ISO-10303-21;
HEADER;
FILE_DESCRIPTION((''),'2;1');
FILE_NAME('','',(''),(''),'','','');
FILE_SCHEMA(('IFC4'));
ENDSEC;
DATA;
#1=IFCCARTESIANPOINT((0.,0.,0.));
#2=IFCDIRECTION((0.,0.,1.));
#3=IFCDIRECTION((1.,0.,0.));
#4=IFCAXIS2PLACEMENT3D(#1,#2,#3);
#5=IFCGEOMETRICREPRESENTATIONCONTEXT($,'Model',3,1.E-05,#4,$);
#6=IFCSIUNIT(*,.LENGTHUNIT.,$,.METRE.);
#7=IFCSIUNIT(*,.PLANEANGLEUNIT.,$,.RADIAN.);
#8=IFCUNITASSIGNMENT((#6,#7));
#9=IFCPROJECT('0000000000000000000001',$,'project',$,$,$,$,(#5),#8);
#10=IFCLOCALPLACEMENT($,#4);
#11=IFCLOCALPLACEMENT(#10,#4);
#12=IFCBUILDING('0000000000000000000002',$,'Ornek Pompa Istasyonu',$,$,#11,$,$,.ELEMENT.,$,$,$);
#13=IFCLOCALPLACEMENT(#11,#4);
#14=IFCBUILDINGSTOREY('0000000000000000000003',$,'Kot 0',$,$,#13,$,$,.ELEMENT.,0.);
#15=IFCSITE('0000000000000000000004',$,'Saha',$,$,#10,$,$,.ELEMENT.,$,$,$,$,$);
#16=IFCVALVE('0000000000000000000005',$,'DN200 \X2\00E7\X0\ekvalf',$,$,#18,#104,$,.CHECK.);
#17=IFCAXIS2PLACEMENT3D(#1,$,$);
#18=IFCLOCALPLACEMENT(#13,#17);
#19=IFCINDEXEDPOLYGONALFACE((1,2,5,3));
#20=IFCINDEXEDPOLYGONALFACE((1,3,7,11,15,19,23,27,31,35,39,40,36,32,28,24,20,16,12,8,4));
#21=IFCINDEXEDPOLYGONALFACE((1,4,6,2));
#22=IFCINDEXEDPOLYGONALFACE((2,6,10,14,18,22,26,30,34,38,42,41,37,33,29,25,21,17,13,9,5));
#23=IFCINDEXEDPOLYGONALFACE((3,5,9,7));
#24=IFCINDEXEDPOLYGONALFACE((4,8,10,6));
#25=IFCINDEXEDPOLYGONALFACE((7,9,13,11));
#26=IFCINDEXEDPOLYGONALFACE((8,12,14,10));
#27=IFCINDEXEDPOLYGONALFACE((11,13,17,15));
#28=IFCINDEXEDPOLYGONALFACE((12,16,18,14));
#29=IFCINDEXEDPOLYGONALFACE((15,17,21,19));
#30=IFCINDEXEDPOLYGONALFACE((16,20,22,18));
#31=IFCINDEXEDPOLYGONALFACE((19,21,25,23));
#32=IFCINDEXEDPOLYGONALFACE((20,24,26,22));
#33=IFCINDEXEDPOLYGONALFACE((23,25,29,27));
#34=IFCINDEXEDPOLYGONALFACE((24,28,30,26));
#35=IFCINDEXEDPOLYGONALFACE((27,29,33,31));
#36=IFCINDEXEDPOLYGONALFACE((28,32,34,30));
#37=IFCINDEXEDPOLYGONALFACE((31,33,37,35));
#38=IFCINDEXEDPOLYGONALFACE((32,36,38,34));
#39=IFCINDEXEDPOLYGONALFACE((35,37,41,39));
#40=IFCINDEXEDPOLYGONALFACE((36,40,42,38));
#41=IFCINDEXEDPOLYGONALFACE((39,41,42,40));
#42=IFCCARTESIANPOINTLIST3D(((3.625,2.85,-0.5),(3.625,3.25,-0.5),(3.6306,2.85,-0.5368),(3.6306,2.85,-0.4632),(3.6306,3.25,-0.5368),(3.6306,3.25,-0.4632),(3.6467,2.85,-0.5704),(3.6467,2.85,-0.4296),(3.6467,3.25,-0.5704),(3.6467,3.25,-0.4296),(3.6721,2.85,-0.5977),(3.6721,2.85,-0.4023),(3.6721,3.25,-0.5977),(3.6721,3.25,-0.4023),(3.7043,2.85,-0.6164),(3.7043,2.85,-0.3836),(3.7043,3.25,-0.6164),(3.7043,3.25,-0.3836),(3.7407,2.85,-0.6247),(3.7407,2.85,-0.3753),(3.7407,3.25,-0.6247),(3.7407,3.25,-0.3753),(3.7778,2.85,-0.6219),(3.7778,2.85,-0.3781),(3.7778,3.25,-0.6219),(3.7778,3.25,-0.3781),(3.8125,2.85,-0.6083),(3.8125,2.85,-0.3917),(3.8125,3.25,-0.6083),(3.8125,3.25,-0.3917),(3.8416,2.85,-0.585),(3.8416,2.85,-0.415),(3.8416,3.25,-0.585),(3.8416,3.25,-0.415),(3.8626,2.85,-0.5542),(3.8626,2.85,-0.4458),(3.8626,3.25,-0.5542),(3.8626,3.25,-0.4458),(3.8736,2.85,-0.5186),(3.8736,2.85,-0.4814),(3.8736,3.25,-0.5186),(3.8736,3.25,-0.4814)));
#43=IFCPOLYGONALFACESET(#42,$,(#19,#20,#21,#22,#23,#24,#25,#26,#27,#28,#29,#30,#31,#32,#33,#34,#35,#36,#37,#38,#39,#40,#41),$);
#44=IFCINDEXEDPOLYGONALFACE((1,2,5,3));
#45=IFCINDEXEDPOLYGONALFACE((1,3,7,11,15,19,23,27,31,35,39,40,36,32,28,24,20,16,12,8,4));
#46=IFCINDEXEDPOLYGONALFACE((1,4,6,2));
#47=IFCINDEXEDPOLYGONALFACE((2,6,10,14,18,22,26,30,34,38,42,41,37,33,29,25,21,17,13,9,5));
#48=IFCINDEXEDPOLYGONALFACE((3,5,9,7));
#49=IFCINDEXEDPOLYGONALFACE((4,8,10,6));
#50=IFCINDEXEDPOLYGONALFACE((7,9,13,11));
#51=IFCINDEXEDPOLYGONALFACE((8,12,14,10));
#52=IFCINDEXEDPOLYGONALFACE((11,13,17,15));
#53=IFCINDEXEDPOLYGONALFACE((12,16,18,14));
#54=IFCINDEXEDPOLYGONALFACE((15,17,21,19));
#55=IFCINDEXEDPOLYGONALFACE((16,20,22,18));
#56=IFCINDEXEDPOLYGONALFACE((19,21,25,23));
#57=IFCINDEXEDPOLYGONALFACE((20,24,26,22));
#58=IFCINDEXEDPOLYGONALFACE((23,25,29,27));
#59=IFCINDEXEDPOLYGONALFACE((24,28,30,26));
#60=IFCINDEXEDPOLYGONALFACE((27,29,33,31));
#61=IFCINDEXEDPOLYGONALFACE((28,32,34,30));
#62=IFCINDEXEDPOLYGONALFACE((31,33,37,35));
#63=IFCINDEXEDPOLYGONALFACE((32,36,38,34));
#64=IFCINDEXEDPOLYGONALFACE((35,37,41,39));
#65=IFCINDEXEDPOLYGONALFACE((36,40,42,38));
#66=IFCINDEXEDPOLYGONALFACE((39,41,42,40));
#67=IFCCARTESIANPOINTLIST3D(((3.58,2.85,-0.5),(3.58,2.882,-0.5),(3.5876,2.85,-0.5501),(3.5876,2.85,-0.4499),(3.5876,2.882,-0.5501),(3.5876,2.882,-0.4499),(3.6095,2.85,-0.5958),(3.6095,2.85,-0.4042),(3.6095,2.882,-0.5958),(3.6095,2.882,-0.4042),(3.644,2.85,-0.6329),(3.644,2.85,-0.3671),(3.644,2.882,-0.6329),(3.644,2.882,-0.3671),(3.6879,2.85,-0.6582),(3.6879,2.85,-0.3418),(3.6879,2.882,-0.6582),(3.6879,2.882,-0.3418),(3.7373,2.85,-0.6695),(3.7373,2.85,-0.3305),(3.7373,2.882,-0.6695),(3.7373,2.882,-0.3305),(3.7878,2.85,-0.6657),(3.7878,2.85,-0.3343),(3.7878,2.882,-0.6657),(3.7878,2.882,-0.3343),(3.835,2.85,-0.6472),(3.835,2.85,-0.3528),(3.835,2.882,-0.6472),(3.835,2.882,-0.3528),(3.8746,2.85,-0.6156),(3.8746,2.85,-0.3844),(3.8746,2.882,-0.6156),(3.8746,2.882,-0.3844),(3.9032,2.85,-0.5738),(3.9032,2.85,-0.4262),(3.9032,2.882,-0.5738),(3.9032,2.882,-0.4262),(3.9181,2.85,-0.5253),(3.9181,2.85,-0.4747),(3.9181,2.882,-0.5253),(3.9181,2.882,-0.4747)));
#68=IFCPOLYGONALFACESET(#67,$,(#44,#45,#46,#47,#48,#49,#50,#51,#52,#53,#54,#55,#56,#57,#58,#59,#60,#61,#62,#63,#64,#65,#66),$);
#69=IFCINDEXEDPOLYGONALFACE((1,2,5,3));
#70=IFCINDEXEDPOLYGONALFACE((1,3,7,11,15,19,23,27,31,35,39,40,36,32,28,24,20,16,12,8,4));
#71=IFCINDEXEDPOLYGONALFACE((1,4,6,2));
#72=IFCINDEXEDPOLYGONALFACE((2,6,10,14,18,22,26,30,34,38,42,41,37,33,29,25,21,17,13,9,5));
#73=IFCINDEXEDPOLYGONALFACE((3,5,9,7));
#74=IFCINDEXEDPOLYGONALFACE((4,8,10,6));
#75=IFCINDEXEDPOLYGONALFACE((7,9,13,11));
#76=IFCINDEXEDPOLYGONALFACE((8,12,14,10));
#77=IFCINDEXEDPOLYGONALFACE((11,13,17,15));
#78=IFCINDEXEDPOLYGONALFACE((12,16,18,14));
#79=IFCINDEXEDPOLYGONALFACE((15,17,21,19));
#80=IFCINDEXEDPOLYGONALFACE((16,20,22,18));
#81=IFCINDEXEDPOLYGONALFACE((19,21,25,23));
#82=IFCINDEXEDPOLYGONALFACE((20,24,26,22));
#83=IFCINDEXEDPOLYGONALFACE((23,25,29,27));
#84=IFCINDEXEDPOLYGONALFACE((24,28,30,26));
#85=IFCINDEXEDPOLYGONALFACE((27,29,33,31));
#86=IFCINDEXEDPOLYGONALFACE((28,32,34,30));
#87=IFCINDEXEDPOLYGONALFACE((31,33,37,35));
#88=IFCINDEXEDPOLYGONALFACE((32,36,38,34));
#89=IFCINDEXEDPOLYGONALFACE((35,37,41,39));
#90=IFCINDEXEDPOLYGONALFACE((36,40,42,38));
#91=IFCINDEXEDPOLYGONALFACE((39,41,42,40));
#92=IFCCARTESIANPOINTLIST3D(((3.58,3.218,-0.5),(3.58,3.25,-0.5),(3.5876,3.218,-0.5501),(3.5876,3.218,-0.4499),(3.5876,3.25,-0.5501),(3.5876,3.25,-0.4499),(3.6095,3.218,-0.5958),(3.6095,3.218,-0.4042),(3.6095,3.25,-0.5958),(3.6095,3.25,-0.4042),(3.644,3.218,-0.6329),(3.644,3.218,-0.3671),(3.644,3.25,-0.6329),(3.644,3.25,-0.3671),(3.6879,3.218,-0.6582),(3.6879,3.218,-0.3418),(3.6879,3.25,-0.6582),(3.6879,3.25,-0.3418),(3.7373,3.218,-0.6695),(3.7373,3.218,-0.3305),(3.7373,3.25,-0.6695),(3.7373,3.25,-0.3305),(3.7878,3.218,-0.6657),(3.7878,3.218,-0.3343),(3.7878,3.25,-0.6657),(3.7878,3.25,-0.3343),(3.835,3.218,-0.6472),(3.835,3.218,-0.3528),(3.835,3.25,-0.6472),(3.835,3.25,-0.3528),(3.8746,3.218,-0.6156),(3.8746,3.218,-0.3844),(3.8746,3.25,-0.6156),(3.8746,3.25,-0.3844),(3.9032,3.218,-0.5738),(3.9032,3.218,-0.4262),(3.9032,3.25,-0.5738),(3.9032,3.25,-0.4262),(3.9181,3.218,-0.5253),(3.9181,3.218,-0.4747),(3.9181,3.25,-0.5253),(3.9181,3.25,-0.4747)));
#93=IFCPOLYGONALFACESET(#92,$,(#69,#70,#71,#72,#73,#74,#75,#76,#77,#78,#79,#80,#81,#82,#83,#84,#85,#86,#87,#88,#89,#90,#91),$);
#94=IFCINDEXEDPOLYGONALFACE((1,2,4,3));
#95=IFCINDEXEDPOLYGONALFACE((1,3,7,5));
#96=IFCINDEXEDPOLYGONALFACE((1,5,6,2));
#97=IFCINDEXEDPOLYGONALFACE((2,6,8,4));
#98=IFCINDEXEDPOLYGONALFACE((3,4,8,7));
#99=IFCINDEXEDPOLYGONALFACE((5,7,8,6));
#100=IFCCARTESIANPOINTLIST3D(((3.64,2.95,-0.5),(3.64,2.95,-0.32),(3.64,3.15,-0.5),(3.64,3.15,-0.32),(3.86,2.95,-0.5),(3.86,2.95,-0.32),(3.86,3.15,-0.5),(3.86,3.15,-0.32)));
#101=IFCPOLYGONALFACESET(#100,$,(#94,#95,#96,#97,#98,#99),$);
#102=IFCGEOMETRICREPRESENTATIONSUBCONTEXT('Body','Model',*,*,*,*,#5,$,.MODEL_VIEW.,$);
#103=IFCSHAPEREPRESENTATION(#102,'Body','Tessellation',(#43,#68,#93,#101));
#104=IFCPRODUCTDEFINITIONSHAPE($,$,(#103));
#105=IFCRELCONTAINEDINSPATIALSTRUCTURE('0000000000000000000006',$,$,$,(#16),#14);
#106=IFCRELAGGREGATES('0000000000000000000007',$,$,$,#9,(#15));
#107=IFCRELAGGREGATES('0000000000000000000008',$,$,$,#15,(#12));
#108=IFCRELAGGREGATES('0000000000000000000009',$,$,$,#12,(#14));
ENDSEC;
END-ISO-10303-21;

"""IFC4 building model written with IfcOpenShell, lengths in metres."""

from ifc_helpers import new_model, si_unit, frame, origin_with_axes, origin_2d, place, context, subcontext, project, spatial, polyline, circle, outline, extrude, element, save


model = new_model("IFC4")

# Units and contexts
model_context = context("Model", 3, precision=1e-05, world=origin_with_axes())
body_context = subcontext(model_context, "Body", "Model", "MODEL_VIEW")
ifc_project = project(units=[si_unit("LENGTHUNIT", "METRE"), si_unit("PLANEANGLEUNIT", "RADIAN")], contexts=[model_context])

# Site, building, storey
site_placement = place(None, origin_with_axes())
site = spatial("IfcSite", under=ifc_project, at=site_placement, Name="Saha", CompositionType="ELEMENT")
building_placement = place(site_placement, origin_with_axes())
building = spatial("IfcBuilding", under=site, at=building_placement, Name="Ornek Pompa Istasyonu", CompositionType="ELEMENT")
storey_placement = place(building_placement, origin_with_axes())
storey = spatial("IfcBuildingStorey", under=building, at=storey_placement, Name="Kot 0", CompositionType="ELEMENT", Elevation=0.0)

# Valve
valve_1_placement = place(storey_placement, origin_with_axes())
element("IfcValve", 1, at=valve_1_placement, inside=storey, Name="DN200 çekvalf", PredefinedType="CHECK", context=body_context, shape_type="SweptSolid", body=[
    extrude(circle(Radius=0.125, at=origin_2d()), frame((3.75, 2.85, -0.5), z_axis=(0.0, 1.0, 0.0), x_axis=(-1.0, 0.0, 0.0)), (0.0, 0.0, 1.0), 0.4),
    extrude(circle(Radius=0.17, at=origin_2d()), frame((3.75, 2.85, -0.5), z_axis=(0.0, 1.0, 0.0), x_axis=(-1.0, 0.0, 0.0)), (0.0, 0.0, 1.0), 0.032),
    extrude(circle(Radius=0.17, at=origin_2d()), frame((3.75, 3.218, -0.5), z_axis=(0.0, 1.0, 0.0), x_axis=(-1.0, 0.0, 0.0)), (0.0, 0.0, 1.0), 0.032),
    extrude(outline(polyline([(0.0, 0.0), (0.2, 0.0), (0.2, 0.22), (0.0, 0.22), (0.0, 0.0)])), frame((3.86, 2.95, -0.5), z_axis=(0.0, 0.0, 1.0), x_axis=(0.0, 1.0, 0.0)), (0.0, 0.0, 1.0), 0.18),
])

save(model, "model.ifc")
